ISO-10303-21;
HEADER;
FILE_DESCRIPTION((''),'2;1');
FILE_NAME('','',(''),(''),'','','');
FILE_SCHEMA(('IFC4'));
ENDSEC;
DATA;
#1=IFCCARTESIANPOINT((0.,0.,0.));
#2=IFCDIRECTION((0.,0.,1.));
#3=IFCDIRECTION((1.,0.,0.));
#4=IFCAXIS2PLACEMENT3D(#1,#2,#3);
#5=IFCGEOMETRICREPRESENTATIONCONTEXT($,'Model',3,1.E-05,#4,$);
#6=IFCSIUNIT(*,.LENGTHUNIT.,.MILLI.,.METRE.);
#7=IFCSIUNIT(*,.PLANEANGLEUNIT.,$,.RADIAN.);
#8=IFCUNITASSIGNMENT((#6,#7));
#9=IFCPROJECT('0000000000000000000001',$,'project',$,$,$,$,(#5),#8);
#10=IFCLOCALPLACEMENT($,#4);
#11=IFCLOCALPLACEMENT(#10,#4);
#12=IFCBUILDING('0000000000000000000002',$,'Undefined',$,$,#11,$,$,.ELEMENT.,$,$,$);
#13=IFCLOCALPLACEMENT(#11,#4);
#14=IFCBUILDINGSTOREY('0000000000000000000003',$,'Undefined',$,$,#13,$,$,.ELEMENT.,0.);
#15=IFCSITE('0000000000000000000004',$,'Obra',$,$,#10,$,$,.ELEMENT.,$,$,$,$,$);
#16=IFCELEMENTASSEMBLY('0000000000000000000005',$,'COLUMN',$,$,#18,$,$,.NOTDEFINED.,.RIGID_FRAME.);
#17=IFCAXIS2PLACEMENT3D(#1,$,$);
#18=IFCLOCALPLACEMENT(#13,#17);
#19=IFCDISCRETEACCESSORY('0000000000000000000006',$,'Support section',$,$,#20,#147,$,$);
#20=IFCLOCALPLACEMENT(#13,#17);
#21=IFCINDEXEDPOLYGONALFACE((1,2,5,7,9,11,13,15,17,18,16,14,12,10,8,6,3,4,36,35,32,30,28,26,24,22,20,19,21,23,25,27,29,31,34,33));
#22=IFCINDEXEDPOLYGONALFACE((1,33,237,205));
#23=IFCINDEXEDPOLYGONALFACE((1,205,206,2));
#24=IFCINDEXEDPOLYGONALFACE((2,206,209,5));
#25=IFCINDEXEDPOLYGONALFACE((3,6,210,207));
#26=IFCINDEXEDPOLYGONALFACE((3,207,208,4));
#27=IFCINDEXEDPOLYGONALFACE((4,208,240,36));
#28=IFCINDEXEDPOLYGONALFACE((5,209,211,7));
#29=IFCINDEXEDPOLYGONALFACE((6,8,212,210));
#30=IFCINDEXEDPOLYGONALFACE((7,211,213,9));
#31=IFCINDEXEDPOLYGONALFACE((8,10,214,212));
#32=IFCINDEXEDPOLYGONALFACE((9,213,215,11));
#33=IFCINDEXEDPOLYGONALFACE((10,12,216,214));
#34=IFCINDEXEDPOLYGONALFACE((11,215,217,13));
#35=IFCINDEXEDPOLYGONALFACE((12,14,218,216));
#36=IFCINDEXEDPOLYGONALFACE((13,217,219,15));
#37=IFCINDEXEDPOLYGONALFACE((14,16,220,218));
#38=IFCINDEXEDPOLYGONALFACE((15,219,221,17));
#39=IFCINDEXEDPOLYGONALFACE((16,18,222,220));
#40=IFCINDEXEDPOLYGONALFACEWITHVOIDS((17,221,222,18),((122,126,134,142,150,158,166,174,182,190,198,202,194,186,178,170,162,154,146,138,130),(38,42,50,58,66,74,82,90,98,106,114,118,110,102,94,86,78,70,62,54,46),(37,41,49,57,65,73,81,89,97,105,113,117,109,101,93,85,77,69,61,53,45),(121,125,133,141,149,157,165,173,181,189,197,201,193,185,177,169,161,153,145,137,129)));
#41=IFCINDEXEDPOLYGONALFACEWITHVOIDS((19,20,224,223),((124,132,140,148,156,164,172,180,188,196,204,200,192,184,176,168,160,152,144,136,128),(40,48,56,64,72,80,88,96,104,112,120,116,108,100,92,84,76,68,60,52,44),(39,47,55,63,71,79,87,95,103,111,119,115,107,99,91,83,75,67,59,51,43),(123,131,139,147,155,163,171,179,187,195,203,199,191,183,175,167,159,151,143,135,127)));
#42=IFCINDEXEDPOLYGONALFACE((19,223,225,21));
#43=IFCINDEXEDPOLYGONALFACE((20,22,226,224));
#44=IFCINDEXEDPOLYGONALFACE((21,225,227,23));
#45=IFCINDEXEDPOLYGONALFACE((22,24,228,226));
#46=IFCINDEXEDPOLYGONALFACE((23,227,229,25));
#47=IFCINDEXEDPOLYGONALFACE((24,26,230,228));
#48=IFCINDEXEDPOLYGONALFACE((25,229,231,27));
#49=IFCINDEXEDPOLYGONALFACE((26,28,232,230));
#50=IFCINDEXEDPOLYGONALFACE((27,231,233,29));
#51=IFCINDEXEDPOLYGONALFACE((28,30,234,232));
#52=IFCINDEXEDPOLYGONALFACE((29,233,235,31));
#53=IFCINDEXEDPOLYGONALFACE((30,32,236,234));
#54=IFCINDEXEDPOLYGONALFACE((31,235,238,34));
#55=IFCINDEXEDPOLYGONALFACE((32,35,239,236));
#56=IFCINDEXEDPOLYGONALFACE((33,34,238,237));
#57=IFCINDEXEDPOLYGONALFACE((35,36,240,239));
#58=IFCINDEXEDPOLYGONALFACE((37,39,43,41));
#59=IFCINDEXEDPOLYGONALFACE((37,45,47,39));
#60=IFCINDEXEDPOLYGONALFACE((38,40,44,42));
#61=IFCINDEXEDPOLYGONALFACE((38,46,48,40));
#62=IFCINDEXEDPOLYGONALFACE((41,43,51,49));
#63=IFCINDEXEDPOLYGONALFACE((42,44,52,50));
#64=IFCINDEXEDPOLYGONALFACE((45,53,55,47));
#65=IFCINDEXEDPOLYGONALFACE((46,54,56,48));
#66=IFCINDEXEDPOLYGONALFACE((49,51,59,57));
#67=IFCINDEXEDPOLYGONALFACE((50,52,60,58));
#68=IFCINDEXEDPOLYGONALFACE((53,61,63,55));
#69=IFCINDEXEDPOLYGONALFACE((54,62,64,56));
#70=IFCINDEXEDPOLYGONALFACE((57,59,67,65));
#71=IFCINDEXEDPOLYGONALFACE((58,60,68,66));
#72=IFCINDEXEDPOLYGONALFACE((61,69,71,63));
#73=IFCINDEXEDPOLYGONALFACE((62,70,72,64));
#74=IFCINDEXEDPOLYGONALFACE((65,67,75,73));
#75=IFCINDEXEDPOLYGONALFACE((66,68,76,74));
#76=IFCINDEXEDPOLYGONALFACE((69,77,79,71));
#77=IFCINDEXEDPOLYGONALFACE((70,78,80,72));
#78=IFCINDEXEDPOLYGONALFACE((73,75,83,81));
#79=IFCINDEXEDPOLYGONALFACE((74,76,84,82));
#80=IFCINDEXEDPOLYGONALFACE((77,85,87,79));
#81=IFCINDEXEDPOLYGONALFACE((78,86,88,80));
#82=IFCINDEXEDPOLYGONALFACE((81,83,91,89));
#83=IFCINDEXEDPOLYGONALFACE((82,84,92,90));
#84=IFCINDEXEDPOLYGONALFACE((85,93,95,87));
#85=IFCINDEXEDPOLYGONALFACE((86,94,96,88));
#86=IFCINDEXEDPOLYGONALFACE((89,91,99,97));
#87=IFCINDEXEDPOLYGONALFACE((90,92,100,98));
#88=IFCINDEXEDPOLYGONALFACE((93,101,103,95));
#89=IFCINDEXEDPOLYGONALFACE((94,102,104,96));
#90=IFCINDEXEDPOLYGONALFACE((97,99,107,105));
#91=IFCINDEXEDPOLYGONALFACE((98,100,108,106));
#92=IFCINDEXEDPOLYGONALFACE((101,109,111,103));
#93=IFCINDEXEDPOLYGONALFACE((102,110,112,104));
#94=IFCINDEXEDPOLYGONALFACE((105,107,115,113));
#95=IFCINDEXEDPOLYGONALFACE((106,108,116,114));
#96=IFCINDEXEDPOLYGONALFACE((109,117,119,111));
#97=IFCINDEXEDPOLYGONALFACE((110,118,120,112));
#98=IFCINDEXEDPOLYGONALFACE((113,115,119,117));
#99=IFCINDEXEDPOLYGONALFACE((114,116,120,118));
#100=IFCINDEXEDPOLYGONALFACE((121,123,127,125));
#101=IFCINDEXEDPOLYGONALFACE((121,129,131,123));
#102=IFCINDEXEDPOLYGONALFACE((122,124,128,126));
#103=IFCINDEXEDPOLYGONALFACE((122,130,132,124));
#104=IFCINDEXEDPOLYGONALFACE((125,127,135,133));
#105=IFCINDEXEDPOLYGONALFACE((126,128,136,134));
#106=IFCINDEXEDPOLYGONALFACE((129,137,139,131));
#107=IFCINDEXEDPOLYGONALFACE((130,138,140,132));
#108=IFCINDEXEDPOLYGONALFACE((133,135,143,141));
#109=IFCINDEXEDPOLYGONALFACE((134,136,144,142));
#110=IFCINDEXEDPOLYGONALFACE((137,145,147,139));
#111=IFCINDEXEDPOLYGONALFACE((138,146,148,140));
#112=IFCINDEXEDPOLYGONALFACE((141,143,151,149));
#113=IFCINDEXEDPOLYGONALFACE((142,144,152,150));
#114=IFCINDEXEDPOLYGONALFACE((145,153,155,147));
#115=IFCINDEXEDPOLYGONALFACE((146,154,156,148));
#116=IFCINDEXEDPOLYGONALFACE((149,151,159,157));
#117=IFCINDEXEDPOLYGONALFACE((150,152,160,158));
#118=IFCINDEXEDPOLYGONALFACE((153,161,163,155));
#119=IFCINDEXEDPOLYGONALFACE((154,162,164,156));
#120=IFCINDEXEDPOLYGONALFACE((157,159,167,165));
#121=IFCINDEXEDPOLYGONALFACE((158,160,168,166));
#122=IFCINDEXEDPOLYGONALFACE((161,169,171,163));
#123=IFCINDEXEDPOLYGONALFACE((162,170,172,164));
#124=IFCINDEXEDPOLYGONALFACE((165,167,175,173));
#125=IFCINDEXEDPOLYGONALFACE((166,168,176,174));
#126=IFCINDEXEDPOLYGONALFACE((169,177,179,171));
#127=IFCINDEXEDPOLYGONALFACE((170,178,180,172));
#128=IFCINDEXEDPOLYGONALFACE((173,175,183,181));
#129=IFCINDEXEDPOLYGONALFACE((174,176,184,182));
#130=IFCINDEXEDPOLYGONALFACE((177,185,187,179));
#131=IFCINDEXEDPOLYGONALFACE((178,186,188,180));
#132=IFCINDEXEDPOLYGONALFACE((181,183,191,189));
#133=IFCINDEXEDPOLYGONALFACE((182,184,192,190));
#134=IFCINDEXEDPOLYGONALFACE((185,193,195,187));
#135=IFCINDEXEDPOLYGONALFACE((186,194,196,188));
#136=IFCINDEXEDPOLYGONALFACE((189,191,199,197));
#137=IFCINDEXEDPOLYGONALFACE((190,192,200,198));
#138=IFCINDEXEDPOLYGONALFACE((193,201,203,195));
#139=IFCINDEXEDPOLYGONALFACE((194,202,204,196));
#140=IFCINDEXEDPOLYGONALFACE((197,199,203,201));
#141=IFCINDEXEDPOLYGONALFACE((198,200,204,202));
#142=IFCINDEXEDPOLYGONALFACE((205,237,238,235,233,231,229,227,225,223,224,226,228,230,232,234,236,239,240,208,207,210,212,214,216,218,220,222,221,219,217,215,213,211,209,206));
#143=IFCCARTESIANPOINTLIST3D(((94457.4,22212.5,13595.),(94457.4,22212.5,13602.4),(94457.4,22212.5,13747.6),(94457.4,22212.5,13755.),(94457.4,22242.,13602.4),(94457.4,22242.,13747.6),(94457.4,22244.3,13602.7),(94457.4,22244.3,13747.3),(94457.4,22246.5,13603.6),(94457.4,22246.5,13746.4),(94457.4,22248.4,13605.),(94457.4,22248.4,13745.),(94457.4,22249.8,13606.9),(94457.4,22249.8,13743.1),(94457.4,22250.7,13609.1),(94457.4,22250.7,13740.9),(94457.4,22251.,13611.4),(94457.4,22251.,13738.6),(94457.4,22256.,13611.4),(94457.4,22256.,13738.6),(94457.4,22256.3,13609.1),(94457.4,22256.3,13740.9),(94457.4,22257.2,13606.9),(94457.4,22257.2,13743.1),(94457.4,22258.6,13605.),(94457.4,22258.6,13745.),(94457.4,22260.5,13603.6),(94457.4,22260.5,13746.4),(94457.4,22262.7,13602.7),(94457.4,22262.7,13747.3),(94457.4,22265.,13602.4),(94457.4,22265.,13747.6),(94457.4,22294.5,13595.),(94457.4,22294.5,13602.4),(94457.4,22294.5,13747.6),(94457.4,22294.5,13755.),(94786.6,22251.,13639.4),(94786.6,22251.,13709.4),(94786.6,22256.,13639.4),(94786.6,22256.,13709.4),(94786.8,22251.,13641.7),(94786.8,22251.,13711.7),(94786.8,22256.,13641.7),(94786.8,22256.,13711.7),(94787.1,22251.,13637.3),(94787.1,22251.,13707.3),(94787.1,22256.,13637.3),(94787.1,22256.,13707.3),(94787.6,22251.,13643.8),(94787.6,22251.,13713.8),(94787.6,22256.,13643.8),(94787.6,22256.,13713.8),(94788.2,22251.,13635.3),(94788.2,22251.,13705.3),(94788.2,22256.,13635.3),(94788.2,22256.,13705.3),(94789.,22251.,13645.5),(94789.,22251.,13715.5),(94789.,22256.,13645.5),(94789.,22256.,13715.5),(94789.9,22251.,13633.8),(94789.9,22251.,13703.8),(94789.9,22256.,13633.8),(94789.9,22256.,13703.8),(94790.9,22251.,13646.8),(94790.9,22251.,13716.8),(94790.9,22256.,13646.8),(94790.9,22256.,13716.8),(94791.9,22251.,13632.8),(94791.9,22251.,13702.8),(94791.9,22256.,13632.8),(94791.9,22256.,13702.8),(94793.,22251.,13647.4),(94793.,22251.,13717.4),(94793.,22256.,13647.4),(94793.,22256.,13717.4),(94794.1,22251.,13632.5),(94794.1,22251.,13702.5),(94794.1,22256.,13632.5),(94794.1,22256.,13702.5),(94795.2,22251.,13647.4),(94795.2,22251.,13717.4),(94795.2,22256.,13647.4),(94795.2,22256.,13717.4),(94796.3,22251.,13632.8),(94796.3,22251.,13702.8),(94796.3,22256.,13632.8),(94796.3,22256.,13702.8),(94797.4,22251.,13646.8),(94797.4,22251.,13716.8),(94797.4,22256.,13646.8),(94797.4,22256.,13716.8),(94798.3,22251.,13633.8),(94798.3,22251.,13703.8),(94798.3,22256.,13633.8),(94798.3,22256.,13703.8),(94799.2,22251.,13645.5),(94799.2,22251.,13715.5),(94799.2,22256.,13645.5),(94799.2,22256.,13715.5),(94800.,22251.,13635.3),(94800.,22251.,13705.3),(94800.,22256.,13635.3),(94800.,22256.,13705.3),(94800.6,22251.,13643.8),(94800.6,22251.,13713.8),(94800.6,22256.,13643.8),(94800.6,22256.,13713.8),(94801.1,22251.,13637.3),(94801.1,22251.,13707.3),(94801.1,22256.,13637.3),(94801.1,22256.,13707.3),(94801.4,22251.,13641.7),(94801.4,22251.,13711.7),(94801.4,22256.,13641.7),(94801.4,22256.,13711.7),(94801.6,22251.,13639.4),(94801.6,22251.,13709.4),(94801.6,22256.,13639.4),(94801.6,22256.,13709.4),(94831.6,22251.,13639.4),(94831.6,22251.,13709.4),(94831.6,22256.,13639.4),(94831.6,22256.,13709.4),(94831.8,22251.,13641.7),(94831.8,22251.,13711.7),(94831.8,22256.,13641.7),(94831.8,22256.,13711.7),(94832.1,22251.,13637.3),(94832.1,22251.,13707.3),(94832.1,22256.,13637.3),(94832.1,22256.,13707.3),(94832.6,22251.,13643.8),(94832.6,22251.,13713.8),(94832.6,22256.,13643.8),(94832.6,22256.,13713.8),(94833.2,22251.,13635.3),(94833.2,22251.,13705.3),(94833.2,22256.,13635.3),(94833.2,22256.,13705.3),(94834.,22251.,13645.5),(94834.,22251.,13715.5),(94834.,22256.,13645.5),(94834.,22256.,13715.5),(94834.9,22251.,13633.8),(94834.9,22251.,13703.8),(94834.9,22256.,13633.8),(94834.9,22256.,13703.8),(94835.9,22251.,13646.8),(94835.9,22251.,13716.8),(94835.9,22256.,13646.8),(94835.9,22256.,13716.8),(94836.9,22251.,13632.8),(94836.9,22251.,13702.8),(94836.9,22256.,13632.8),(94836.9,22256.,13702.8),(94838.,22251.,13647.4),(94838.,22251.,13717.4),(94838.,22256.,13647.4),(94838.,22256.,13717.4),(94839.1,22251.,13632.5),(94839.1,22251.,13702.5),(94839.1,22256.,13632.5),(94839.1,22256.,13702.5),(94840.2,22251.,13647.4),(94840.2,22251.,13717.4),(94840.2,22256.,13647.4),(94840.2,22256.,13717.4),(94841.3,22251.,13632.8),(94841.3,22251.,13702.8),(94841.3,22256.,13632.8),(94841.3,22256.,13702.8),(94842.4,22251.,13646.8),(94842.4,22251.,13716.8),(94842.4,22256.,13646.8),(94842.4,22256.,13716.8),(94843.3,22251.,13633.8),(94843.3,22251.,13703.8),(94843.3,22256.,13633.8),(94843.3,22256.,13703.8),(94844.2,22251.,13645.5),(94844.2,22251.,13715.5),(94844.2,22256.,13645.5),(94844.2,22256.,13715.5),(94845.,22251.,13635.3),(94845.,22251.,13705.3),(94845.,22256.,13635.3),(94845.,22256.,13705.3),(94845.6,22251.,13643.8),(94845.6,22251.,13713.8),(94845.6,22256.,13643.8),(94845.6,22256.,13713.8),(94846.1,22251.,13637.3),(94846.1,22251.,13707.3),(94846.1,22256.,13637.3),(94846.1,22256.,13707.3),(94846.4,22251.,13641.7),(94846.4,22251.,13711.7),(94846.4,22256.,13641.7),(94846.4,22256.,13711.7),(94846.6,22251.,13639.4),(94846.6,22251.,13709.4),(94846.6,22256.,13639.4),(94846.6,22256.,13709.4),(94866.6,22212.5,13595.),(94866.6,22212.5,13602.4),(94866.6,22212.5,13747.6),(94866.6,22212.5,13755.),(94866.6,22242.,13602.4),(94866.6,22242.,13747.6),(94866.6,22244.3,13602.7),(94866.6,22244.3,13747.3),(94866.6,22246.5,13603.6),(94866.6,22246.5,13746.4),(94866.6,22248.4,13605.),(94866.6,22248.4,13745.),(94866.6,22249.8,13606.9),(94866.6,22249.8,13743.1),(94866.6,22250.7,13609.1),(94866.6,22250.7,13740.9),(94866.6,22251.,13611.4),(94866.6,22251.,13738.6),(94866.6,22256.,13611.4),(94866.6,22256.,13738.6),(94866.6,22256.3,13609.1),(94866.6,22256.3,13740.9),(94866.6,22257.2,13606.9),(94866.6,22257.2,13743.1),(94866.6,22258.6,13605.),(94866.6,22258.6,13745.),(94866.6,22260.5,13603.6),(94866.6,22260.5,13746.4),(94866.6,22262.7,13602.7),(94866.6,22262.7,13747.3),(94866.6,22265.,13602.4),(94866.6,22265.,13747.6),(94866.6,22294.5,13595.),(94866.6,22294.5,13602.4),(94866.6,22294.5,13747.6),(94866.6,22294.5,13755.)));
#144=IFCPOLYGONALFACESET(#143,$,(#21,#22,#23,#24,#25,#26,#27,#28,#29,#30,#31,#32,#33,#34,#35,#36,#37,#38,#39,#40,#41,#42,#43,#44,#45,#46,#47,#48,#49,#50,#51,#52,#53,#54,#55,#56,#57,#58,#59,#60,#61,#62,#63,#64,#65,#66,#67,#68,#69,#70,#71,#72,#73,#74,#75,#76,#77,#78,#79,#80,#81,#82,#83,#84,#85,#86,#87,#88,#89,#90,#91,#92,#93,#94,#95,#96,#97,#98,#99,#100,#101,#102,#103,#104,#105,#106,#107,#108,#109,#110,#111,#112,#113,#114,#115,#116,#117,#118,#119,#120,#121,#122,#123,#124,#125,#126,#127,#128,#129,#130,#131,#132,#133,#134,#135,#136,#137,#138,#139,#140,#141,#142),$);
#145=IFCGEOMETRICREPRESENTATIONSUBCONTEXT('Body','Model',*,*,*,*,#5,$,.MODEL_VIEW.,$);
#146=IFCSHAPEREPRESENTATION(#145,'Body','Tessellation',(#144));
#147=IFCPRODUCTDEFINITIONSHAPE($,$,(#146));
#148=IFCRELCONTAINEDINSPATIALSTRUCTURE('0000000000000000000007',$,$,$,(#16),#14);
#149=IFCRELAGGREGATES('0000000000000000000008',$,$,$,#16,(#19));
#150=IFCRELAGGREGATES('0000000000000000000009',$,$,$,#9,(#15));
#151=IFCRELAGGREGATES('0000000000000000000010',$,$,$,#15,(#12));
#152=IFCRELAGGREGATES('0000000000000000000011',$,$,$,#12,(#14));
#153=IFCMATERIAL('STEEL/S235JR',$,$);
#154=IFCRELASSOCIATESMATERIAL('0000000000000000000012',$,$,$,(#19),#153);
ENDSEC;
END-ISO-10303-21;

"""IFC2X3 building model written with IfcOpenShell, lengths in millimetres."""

from ifc_helpers import new_model, si_unit, frame, origin_with_axes, origin_2d_with_axis, place, context, subcontext, project, spatial, circle, i_section, extrude, clip, halfspace, source, transform, mapped, material, element, aggregate, save


model = new_model("IFC2X3")

# Units and contexts
model_context = context("Model", 3, precision=1e-05, world=origin_with_axes())
body_context = subcontext(model_context, "Body", "Model", "MODEL_VIEW")
ifc_project = project(units=[si_unit("LENGTHUNIT", "METRE", prefix="MILLI"), si_unit("PLANEANGLEUNIT", "RADIAN")], contexts=[model_context])

# Site, building, storey
site_placement = place(None, origin_with_axes())
site = spatial("IfcSite", under=ifc_project, at=site_placement, Name="Obra", CompositionType="ELEMENT")
building_placement = place(site_placement, origin_with_axes())
building = spatial("IfcBuilding", under=site, at=building_placement, Name="Undefined", CompositionType="ELEMENT")
storey_placement = place(building_placement, origin_with_axes())
storey = spatial("IfcBuildingStorey", under=building, at=storey_placement, Name="Undefined", CompositionType="ELEMENT", Elevation=0.0)

# Element assembly, discrete accessory, opening
assembly_placement = place(storey_placement, origin_with_axes())
assembly = element("IfcElementAssembly", 1, at=assembly_placement, inside=storey, Name="COLUMN", AssemblyPlace="NOTDEFINED", PredefinedType="RIGID_FRAME")
ifc_material_1 = material(Name="STEEL/S235JR")
shared_shape_1 = source(origin_with_axes(), body_context, "Body", "SweptSolid", [
    extrude(circle(Radius=7.5, at=origin_2d_with_axis()), frame((0.0, -2.6, 0.0), z_axis=(0.0, 1.0, 0.0), x_axis=(1.0, 0.0, 0.0)), (0.0, 0.0, 1.0), 5.2),
])
discrete_accessory_1_placement = place(assembly_placement, frame((94458.3, 22253.5, 13675.0), z_axis=(0.0, 0.0, 1.0), x_axis=(1.0, 0.0, 0.0)))
discrete_accessory_1 = element("IfcDiscreteAccessory", 2, at=discrete_accessory_1_placement, material=ifc_material_1, Name="Support section", context=body_context, shape_type="Clipping", body=[
    clip(clip(extrude(i_section(OverallWidth=82.0, OverallDepth=160.0, WebThickness=5.0, FlangeThickness=7.4, FilletRadius=9.0, at=origin_2d_with_axis()), frame((408.3, 0.0, 0.0), z_axis=(-1.0, 0.0, 0.0), x_axis=(0.0, -1.0, 0.0)), (0.0, 0.0, 1.0), 409.2), halfspace(frame((408.3, 0.0, -180.0), z_axis=(-1.0, 0.0, 0.0), x_axis=(0.0, 1.0, 0.0)), True)), halfspace(frame((-0.9, 0.0, 580.0), z_axis=(-1.0, -0.000033, 0.0), x_axis=(0.000033, -1.0, 0.0)), False)),
])
opening_1_placement = place(assembly_placement, frame((94816.6, 22253.5, 13710.0), z_axis=(-1.0, 0.0, 0.0), x_axis=(0.0, 0.0, -1.0)))
element("IfcOpeningElement", 3, at=opening_1_placement, cuts=discrete_accessory_1, ObjectType="Opening", context=body_context, shape_type="MappedRepresentation", body=[
    mapped(shared_shape_1, transform((0.0, 0.0, -22.5))),
    mapped(shared_shape_1, transform((70.0, 0.0, -22.5))),
    mapped(shared_shape_1, transform((0.0, 0.0, 22.5))),
    mapped(shared_shape_1, transform((70.0, 0.0, 22.5))),
])
aggregate(assembly, [discrete_accessory_1])

save(model, "model.ifc")
